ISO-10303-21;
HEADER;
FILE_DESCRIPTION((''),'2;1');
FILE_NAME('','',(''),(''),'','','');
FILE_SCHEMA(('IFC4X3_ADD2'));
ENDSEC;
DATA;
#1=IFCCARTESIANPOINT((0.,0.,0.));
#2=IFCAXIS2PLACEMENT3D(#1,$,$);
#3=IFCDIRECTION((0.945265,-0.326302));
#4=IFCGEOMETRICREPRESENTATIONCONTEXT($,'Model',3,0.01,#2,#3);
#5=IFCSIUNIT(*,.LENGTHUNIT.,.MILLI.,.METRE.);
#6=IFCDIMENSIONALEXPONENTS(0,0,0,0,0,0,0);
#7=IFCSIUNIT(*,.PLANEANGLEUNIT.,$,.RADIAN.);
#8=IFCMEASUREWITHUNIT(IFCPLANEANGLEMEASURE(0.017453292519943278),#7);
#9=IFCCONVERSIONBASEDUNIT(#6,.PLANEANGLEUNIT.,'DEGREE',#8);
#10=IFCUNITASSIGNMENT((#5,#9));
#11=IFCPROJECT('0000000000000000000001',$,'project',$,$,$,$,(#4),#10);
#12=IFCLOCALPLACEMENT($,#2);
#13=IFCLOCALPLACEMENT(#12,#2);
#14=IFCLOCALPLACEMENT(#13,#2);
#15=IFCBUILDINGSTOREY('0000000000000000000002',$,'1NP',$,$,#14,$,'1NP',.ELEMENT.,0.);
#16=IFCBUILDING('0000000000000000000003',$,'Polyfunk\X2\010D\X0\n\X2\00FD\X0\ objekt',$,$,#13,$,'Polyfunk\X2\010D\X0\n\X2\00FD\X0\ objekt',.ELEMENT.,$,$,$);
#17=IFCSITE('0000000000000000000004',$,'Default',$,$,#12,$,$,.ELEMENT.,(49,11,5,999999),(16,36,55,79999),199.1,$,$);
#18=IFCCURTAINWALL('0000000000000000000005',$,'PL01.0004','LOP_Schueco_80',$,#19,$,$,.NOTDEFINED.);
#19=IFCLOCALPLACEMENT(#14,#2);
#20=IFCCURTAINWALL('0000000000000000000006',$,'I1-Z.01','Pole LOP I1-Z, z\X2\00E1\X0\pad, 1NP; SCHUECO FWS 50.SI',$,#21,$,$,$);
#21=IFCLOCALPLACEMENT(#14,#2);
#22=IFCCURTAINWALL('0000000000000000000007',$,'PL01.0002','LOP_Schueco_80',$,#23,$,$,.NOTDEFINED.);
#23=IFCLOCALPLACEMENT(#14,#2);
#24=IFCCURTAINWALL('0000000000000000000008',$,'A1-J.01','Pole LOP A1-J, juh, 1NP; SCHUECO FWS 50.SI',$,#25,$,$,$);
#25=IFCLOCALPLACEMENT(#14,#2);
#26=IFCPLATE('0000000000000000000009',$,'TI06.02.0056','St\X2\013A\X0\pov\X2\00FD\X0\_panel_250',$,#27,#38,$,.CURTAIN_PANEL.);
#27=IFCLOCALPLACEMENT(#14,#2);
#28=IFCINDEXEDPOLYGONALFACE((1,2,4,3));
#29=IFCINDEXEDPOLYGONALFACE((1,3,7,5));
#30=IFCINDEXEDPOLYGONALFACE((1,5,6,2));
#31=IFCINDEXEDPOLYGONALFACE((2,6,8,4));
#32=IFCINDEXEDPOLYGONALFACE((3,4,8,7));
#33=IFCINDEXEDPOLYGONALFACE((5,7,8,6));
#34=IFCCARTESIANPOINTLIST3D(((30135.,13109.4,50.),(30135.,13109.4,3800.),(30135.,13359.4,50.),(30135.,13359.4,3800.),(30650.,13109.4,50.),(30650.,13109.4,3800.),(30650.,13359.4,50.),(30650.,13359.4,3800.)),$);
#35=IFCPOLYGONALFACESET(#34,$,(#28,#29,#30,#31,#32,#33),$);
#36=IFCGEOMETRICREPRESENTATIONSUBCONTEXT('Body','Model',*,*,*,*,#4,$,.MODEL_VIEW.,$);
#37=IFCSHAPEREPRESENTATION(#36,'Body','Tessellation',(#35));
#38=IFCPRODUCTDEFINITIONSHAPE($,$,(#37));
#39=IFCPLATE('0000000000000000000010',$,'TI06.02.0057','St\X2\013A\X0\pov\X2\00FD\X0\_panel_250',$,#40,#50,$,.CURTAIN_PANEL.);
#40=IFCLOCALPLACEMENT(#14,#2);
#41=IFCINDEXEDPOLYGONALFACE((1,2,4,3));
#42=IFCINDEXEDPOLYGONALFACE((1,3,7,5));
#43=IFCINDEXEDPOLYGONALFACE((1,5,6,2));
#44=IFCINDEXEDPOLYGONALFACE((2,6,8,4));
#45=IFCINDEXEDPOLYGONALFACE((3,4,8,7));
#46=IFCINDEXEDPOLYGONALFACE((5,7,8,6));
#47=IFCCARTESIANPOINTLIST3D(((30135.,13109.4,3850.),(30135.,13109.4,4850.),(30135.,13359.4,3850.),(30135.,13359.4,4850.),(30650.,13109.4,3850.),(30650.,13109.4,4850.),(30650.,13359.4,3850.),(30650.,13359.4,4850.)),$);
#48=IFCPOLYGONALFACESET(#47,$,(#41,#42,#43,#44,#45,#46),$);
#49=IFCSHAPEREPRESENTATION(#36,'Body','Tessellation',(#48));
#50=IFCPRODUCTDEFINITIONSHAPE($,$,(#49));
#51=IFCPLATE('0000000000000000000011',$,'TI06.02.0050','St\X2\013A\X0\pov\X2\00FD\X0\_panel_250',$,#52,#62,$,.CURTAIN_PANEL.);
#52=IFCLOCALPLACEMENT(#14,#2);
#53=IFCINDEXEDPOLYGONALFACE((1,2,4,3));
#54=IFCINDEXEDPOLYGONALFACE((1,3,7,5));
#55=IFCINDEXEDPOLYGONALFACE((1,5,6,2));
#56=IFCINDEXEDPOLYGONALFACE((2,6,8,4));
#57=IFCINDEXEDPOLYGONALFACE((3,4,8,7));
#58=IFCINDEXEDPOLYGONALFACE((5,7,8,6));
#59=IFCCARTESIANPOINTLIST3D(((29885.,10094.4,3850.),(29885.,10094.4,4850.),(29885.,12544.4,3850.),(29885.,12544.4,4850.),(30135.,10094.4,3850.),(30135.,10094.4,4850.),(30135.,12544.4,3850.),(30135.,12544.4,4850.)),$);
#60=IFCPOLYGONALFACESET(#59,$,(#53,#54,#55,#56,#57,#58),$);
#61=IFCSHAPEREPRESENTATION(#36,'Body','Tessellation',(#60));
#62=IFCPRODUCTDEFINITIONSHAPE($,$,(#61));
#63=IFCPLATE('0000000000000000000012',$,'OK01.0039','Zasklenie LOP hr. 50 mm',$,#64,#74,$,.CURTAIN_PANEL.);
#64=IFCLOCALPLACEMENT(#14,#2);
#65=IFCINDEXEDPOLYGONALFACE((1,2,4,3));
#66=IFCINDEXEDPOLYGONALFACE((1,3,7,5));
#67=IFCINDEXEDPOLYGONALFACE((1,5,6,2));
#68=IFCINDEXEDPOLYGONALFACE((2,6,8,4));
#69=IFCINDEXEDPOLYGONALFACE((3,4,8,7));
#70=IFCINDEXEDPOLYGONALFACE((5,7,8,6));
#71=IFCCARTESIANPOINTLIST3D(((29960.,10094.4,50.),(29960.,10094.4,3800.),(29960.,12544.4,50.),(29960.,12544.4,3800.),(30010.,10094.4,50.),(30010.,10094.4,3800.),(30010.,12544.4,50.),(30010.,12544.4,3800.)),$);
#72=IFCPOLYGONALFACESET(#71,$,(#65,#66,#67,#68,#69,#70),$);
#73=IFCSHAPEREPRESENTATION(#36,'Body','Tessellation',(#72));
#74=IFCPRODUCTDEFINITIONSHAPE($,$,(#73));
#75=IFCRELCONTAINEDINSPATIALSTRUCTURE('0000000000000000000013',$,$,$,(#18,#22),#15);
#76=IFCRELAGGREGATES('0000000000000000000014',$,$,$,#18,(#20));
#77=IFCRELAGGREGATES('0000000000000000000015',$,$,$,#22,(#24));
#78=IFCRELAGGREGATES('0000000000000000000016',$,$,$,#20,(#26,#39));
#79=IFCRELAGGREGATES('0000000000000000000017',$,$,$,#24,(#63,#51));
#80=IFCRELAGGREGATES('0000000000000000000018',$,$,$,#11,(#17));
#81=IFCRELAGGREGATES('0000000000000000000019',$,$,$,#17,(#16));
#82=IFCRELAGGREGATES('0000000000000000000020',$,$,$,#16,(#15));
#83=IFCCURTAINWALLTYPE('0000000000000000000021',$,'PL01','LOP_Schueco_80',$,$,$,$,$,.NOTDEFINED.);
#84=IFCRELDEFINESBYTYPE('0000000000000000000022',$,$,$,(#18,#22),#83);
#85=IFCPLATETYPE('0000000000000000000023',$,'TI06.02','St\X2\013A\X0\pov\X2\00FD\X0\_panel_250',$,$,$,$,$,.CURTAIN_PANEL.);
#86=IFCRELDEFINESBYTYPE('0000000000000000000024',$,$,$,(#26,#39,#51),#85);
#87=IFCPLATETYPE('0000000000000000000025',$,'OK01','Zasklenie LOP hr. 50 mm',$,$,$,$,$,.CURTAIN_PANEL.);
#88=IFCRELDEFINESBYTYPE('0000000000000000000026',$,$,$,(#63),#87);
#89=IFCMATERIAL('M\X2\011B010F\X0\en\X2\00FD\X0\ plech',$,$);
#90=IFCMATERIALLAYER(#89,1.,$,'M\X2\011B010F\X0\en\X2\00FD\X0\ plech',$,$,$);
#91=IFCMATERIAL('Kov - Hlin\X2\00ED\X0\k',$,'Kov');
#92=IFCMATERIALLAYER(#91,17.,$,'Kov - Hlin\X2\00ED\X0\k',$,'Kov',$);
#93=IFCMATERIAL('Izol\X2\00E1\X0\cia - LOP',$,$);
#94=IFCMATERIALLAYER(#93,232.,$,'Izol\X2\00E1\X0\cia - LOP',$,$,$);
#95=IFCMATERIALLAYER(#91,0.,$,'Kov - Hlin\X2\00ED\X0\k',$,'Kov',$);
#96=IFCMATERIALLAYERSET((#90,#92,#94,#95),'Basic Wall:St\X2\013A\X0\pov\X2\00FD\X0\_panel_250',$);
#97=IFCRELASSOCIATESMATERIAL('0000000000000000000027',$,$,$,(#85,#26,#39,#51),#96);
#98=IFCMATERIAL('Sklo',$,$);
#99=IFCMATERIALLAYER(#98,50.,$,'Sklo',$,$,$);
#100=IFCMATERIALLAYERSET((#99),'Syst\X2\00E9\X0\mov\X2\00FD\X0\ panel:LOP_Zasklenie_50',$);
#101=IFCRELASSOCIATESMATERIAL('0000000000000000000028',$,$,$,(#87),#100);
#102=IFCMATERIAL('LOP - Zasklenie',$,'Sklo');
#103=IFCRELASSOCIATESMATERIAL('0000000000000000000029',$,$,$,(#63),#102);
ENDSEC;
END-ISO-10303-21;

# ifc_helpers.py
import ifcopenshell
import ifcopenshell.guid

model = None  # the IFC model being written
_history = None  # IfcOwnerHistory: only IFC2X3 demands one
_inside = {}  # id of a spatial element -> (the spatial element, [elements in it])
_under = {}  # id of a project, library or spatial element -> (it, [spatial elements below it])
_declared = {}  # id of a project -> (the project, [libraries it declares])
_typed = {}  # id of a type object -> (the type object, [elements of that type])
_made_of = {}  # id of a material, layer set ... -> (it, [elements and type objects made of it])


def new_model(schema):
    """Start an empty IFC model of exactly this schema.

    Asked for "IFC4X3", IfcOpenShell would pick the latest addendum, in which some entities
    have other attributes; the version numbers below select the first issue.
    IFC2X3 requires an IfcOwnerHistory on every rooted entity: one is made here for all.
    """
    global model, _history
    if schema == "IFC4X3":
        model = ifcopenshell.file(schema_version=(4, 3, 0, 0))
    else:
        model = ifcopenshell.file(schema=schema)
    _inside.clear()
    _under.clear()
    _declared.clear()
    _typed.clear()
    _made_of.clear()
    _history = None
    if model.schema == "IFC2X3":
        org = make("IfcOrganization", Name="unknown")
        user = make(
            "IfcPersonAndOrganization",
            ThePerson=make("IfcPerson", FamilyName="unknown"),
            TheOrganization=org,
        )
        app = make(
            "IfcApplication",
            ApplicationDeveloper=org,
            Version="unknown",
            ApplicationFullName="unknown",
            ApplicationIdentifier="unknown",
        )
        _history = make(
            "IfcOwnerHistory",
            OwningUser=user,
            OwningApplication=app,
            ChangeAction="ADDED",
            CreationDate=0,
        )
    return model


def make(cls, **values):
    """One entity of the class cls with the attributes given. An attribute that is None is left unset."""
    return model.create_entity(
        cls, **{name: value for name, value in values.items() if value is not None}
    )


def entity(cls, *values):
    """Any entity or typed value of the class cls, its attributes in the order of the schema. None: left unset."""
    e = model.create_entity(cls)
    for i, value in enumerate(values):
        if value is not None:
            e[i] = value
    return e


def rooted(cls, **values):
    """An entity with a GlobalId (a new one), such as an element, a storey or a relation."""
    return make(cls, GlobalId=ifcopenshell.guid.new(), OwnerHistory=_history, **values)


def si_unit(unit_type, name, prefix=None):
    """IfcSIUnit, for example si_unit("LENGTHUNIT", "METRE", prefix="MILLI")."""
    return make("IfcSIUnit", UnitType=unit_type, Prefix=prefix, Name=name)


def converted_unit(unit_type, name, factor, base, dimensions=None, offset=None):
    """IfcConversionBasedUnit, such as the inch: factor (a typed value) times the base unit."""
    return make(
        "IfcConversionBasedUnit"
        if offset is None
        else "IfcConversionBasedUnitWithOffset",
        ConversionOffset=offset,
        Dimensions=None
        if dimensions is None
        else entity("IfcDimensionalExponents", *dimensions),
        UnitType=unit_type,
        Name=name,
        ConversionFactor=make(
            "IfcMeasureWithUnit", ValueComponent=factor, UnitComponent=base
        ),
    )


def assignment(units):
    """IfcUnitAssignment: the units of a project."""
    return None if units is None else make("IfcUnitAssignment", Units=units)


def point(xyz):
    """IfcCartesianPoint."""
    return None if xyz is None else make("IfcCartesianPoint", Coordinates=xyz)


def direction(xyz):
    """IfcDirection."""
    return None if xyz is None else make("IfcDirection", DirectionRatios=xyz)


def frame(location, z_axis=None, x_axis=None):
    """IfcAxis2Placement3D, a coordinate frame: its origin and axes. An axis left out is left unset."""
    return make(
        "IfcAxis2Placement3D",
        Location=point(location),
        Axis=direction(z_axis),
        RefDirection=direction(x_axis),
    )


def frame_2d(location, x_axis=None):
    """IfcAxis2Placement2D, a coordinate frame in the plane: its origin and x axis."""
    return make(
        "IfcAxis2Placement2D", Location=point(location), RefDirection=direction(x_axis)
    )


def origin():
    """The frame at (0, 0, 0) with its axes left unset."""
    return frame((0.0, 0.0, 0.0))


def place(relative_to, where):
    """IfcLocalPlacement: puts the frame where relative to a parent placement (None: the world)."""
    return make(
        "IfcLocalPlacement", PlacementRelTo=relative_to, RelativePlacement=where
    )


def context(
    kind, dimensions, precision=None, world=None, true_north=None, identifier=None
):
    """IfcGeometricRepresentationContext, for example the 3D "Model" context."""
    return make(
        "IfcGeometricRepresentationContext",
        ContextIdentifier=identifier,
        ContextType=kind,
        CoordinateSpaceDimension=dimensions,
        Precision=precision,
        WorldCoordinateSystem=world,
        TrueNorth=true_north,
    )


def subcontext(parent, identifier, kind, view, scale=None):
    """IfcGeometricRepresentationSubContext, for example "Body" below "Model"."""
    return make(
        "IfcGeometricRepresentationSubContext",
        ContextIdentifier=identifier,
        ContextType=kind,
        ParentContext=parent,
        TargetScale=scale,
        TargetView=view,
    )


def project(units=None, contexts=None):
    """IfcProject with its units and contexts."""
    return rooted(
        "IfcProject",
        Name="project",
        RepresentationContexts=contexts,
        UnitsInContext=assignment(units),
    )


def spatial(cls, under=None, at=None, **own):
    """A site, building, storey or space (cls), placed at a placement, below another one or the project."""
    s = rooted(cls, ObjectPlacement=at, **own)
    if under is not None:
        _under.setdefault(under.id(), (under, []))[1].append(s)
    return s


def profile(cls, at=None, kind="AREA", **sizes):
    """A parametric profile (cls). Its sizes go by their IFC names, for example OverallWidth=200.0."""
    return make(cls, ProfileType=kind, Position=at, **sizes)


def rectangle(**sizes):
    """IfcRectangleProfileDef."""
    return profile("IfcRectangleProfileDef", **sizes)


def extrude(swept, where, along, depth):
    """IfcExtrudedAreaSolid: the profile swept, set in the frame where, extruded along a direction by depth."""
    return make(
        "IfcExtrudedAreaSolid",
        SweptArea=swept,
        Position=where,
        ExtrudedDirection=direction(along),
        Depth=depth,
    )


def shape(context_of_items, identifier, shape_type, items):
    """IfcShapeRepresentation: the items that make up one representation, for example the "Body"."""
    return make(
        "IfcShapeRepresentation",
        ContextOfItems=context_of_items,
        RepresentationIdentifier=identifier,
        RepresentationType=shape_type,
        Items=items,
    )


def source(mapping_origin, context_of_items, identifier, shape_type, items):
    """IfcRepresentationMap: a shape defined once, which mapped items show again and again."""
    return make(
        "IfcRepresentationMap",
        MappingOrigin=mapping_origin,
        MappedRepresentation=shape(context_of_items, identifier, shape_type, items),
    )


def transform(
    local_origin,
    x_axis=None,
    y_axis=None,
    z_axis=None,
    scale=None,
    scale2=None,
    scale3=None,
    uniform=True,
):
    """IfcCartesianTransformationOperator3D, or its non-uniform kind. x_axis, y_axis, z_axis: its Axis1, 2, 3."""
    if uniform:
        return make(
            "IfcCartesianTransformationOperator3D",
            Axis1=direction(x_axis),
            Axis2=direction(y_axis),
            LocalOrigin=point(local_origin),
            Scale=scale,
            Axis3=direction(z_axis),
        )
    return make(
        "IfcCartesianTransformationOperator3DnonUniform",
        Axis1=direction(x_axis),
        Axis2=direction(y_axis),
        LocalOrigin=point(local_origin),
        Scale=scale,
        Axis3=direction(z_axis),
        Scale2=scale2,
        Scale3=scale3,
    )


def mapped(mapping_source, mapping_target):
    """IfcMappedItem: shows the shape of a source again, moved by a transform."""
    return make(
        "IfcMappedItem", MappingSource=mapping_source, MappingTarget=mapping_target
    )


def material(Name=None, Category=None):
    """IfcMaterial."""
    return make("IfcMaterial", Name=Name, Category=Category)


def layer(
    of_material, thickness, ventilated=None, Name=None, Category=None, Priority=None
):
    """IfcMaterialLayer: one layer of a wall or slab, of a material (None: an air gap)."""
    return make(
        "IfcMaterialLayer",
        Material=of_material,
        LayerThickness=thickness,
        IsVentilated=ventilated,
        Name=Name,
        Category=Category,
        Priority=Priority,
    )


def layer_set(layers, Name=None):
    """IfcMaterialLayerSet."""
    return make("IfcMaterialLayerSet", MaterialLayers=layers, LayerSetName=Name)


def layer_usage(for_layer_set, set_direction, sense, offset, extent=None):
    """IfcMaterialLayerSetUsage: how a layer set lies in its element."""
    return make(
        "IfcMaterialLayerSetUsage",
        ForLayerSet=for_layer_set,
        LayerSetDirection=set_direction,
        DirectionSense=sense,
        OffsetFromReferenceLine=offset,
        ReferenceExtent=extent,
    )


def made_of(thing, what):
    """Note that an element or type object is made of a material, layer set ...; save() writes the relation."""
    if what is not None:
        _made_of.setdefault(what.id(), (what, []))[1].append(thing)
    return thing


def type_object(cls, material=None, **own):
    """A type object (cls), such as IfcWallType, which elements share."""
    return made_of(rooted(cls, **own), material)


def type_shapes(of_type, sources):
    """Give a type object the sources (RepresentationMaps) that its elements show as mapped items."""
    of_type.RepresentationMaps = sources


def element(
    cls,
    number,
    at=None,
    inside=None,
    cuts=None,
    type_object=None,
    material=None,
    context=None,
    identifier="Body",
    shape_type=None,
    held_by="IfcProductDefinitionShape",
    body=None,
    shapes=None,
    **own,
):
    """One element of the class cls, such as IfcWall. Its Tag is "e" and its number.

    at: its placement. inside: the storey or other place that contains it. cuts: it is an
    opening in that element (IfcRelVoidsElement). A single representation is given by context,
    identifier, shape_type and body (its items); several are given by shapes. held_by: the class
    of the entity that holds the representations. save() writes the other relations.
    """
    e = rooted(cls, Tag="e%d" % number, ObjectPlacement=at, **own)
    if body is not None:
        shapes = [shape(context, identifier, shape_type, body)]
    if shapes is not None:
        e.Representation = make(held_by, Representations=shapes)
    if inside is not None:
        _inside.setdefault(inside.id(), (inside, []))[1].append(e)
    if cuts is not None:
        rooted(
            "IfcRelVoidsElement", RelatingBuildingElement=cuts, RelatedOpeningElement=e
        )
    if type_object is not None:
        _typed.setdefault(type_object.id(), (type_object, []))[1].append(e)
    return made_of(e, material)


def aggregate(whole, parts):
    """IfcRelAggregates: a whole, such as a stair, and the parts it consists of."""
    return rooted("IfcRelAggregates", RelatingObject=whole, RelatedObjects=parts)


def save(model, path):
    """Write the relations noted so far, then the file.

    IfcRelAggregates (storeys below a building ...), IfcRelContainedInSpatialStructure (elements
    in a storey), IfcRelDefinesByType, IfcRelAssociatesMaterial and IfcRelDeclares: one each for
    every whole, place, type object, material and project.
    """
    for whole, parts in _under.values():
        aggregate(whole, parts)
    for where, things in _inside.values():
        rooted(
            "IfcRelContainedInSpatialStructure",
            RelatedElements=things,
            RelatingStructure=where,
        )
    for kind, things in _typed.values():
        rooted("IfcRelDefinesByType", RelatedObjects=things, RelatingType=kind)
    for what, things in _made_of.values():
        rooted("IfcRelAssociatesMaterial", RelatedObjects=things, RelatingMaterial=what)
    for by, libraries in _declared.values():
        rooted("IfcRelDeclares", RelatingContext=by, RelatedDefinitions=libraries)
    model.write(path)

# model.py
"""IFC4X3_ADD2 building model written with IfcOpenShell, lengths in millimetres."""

from ifc_helpers import new_model, entity, si_unit, converted_unit, direction, frame, frame_2d, origin, place, context, subcontext, project, spatial, rectangle, extrude, source, transform, mapped, material, layer, layer_set, layer_usage, type_object, type_shapes, element, aggregate, save


model = new_model("IFC4X3_ADD2")

# Units and contexts
model_context = context("Model", 3, precision=0.01, world=origin(), true_north=direction((0.945265, -0.326302)))
body_context = subcontext(model_context, "Body", "Model", "MODEL_VIEW")
ifc_project = project(units=[si_unit("LENGTHUNIT", "METRE", prefix="MILLI"), converted_unit("PLANEANGLEUNIT", "DEGREE", entity("IfcPlaneAngleMeasure", 0.017453292519943278), si_unit("PLANEANGLEUNIT", "RADIAN"), dimensions=[0, 0, 0, 0, 0, 0, 0])], contexts=[model_context])

# Site, building, storey
site_placement = place(None, origin())
site = spatial("IfcSite", under=ifc_project, at=site_placement, Name="Default", CompositionType="ELEMENT", RefLatitude=(49, 11, 5, 999999), RefLongitude=(16, 36, 55, 79999), RefElevation=199.1)
building_placement = place(site_placement, origin())
building = spatial("IfcBuilding", under=site, at=building_placement, Name="Polyfunkčný objekt", LongName="Polyfunkčný objekt", CompositionType="ELEMENT")
storey_placement = place(building_placement, origin())
storey = spatial("IfcBuildingStorey", under=building, at=storey_placement, Name="1NP", LongName="1NP", CompositionType="ELEMENT", Elevation=0.0)

# Curtain walls
curtain_wall_type = type_object("IfcCurtainWallType", Name="PL01", Description="LOP_Schueco_80", PredefinedType="NOTDEFINED")
curtain_wall_1_placement = place(storey_placement, origin())
curtain_wall_1 = element("IfcCurtainWall", 1, at=curtain_wall_1_placement, inside=storey, type_object=curtain_wall_type, Name="PL01.0004", Description="LOP_Schueco_80", PredefinedType="NOTDEFINED")
curtain_wall_2 = element("IfcCurtainWall", 2, Name="I1-Z.01", Description="Pole LOP I1-Z, západ, 1NP; SCHUECO FWS 50.SI")
aggregate(curtain_wall_1, [curtain_wall_2])
curtain_wall_3_placement = place(storey_placement, origin())
curtain_wall_3 = element("IfcCurtainWall", 3, at=curtain_wall_3_placement, inside=storey, type_object=curtain_wall_type, Name="PL01.0002", Description="LOP_Schueco_80", PredefinedType="NOTDEFINED")
curtain_wall_4 = element("IfcCurtainWall", 4, Name="A1-J.01", Description="Pole LOP A1-J, juh, 1NP; SCHUECO FWS 50.SI")
aggregate(curtain_wall_3, [curtain_wall_4])

# Plates
ifc_material_1 = material(Name="Měďený plech")
ifc_layer_1 = layer(ifc_material_1, 1.0, Name="Měďený plech")
ifc_material_2 = material(Name="Kov - Hliník", Category="Kov")
ifc_layer_2 = layer(ifc_material_2, 17.0, Name="Kov - Hliník", Category="Kov")
ifc_material_3 = material(Name="Izolácia - LOP")
ifc_layer_3 = layer(ifc_material_3, 232.0, Name="Izolácia - LOP")
ifc_layer_4 = layer(ifc_material_2, 0.0, Name="Kov - Hliník", Category="Kov")
ifc_layer_set_1 = layer_set([ifc_layer_1, ifc_layer_2, ifc_layer_3, ifc_layer_4], Name="Basic Wall:Stĺpový_panel_250")
ifc_layer_usage_1 = layer_usage(ifc_layer_set_1, "AXIS2", "NEGATIVE", 125.0)
plate_type_1 = type_object("IfcPlateType", Name="TI06.02", Description="Stĺpový_panel_250", PredefinedType="CURTAIN_PANEL", material=ifc_layer_set_1)
plate_1_placement = place(storey_placement, frame((30135.0, 13234.4, 50.0)))
plate_1 = element("IfcPlate", 5, at=plate_1_placement, type_object=plate_type_1, material=ifc_layer_usage_1, Name="TI06.02.0056", Description="Stĺpový_panel_250", PredefinedType="CURTAIN_PANEL", context=body_context, shape_type="SweptSolid", body=[
    extrude(rectangle(XDim=250.0, YDim=515.0, at=frame_2d((0.0, 0.0), x_axis=(1.0, 0.0))), frame((257.5, 0.0, 0.0), z_axis=(0.0, 0.0, 1.0), x_axis=(0.0, 1.0, 0.0)), (0.0, 0.0, 1.0), 3750.0),
])
ifc_layer_usage_2 = layer_usage(ifc_layer_set_1, "AXIS2", "NEGATIVE", 125.0)
plate_2_placement = place(storey_placement, frame((30135.0, 13234.4, 3850.0)))
plate_2 = element("IfcPlate", 6, at=plate_2_placement, type_object=plate_type_1, material=ifc_layer_usage_2, Name="TI06.02.0057", Description="Stĺpový_panel_250", PredefinedType="CURTAIN_PANEL", context=body_context, shape_type="SweptSolid", body=[
    extrude(rectangle(XDim=250.0, YDim=515.0, at=frame_2d((0.0, 0.0), x_axis=(1.0, 0.0))), frame((257.5, 0.0, 0.0), z_axis=(0.0, 0.0, 1.0), x_axis=(0.0, 1.0, 0.0)), (0.0, 0.0, 1.0), 1000.0),
])
aggregate(curtain_wall_2, [plate_1, plate_2])
ifc_layer_usage_3 = layer_usage(ifc_layer_set_1, "AXIS2", "POSITIVE", -125.0)
plate_3_placement = place(storey_placement, frame((30010.0, 12544.4, 3850.0), z_axis=(0.0, 0.0, 1.0), x_axis=(0.0, -1.0, 0.0)))
plate_3 = element("IfcPlate", 7, at=plate_3_placement, type_object=plate_type_1, material=ifc_layer_usage_3, Name="TI06.02.0050", Description="Stĺpový_panel_250", PredefinedType="CURTAIN_PANEL", context=body_context, shape_type="SweptSolid", body=[
    extrude(rectangle(XDim=250.0, YDim=2450.0, at=frame_2d((0.0, 0.0), x_axis=(1.0, 0.0))), frame((1225.0, 0.0, 0.0), z_axis=(0.0, 0.0, 1.0), x_axis=(0.0, 1.0, 0.0)), (0.0, 0.0, 1.0), 1000.0),
])
ifc_material_4 = material(Name="LOP - Zasklenie", Category="Sklo")
ifc_material_5 = material(Name="Sklo")
ifc_layer_5 = layer(ifc_material_5, 50.0, Name="Sklo")
ifc_layer_set_2 = layer_set([ifc_layer_5], Name="Systémový panel:LOP_Zasklenie_50")
plate_type_2 = type_object("IfcPlateType", Name="OK01", Description="Zasklenie LOP hr. 50 mm", PredefinedType="CURTAIN_PANEL", material=ifc_layer_set_2)
shared_shape_1 = source(origin(), body_context, "Body", "SweptSolid", [
    extrude(rectangle(XDim=3750.0, YDim=2450.0, at=frame_2d((-141.7, 0.0), x_axis=(1.0, 0.0))), frame((0.0, -50.0, 2016.7), z_axis=(0.0, 1.0, 0.0), x_axis=(0.0, 0.0, 1.0)), (0.0, 0.0, 1.0), 50.0),
])
type_shapes(plate_type_2, [shared_shape_1])
plate_4_placement = place(curtain_wall_3_placement, frame((30010.0, 11319.4, 50.0), z_axis=(0.0, 0.0, 1.0), x_axis=(0.0, -1.0, 0.0)))
plate_4 = element("IfcPlate", 8, at=plate_4_placement, type_object=plate_type_2, material=ifc_material_4, Name="OK01.0039", Description="Zasklenie LOP hr. 50 mm", PredefinedType="CURTAIN_PANEL", context=body_context, shape_type="MappedRepresentation", body=[
    mapped(shared_shape_1, transform((0.0, 0.0, 0.0), scale=1.0)),
])
aggregate(curtain_wall_4, [plate_4, plate_3])

save(model, "model.ifc")
